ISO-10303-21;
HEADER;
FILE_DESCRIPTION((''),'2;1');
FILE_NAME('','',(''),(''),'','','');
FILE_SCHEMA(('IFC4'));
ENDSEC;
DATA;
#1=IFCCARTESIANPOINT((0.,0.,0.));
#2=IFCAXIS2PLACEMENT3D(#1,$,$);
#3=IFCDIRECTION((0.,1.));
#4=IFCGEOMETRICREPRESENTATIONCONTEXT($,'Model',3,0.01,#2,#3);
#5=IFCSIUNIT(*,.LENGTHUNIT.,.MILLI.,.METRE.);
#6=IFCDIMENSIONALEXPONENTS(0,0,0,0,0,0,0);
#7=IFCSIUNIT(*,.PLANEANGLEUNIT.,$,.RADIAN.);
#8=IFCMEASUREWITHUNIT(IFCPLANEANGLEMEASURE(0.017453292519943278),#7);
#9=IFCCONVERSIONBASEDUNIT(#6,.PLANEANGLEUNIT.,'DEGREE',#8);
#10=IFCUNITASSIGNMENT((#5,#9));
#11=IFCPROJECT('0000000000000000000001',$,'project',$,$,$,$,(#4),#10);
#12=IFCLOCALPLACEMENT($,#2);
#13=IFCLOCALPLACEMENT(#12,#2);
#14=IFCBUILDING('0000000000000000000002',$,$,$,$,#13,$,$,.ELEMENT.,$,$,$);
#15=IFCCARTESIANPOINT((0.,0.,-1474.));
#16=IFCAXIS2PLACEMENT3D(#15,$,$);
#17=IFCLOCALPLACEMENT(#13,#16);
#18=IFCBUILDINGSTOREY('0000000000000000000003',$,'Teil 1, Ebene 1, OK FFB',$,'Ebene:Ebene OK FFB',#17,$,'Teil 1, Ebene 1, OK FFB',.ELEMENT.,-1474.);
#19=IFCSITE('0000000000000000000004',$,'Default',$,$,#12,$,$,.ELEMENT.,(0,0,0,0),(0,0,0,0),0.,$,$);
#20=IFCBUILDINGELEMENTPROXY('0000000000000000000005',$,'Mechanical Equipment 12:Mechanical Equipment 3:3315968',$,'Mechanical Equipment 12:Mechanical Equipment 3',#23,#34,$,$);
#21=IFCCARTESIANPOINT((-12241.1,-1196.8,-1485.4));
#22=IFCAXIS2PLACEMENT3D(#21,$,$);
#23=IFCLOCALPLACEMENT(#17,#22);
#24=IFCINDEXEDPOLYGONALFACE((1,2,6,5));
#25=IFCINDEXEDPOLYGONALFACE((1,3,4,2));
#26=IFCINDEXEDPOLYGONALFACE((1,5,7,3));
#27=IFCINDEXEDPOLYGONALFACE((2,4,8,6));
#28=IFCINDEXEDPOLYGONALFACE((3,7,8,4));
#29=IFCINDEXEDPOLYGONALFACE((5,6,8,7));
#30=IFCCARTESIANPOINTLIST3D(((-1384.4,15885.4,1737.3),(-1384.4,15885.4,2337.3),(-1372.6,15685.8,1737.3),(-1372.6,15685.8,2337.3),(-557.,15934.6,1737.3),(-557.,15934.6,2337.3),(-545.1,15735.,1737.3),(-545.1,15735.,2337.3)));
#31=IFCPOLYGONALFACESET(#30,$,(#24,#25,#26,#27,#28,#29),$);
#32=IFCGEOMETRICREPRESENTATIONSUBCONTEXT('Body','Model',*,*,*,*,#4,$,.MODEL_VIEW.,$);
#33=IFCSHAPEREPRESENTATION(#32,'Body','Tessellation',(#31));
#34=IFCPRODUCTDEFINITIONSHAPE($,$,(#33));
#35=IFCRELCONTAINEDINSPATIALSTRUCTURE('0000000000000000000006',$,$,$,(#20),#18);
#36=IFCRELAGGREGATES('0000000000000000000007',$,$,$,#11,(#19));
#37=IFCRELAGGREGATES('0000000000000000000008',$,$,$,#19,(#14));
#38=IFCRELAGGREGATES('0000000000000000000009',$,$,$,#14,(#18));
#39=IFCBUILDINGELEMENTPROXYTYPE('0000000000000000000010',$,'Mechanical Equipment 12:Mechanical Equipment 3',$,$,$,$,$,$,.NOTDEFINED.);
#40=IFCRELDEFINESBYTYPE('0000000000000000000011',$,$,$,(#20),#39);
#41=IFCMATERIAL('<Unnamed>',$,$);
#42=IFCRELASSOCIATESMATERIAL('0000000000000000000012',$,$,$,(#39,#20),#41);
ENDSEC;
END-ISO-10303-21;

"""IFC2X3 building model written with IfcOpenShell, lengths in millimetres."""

from ifc_helpers import new_model, entity, si_unit, converted_unit, direction, frame, frame_2d, origin, place, context, subcontext, project, spatial, rectangle, extrude, source, transform, mapped, material, type_object, type_shapes, element, save


model = new_model("IFC2X3")

# Units and contexts
model_context = context("Model", 3, precision=0.01, world=origin(), true_north=direction((0.0, 1.0)))
body_context = subcontext(model_context, "Body", "Model", "MODEL_VIEW")
ifc_project = project(units=[si_unit("LENGTHUNIT", "METRE", prefix="MILLI"), converted_unit("PLANEANGLEUNIT", "DEGREE", entity("IfcPlaneAngleMeasure", 0.017453292519943278), si_unit("PLANEANGLEUNIT", "RADIAN"), dimensions=[0, 0, 0, 0, 0, 0, 0])], contexts=[model_context])

# Site, building, storey
site_placement = place(None, origin())
site = spatial("IfcSite", under=ifc_project, at=site_placement, Name="Default", CompositionType="ELEMENT", RefLatitude=(0, 0, 0, 0), RefLongitude=(0, 0, 0, 0), RefElevation=0.0)
building_placement = place(site_placement, origin())
building = spatial("IfcBuilding", under=site, at=building_placement, CompositionType="ELEMENT")
storey_placement = place(building_placement, frame((0.0, 0.0, -1474.0)))
storey = spatial("IfcBuildingStorey", under=building, at=storey_placement, Name="Teil 1, Ebene 1, OK FFB", ObjectType="Ebene:Ebene OK FFB", LongName="Teil 1, Ebene 1, OK FFB", CompositionType="ELEMENT", Elevation=-1474.0)

# Building element proxy
ifc_material_1 = material(Name="<Unnamed>")
building_element_proxy_type = type_object("IfcBuildingElementProxyType", Name="Mechanical Equipment 12:Mechanical Equipment 3", PredefinedType="NOTDEFINED", material=ifc_material_1)
shared_shape = source(origin(), body_context, "Body", "SweptSolid", [
    extrude(rectangle(XDim=200.0, YDim=828.9, at=frame_2d((0.0, 0.0), x_axis=(1.0, 0.0))), frame((-964.8, 15810.2, 1737.3), z_axis=(0.0, 0.0, 1.0), x_axis=(0.059319, -0.998239, 0.0)), (0.0, 0.0, 1.0), 600.0),
])
type_shapes(building_element_proxy_type, [shared_shape])
proxy_placement = place(storey_placement, frame((-12241.1, -1196.8, -1485.4)))
element("IfcBuildingElementProxy", 1, at=proxy_placement, inside=storey, type_object=building_element_proxy_type, material=ifc_material_1, Name="Mechanical Equipment 12:Mechanical Equipment 3:3315968", ObjectType="Mechanical Equipment 12:Mechanical Equipment 3", context=body_context, shape_type="MappedRepresentation", body=[
    mapped(shared_shape, transform((0.0, 0.0, 0.0), scale=1.0)),
])

save(model, "model.ifc")
